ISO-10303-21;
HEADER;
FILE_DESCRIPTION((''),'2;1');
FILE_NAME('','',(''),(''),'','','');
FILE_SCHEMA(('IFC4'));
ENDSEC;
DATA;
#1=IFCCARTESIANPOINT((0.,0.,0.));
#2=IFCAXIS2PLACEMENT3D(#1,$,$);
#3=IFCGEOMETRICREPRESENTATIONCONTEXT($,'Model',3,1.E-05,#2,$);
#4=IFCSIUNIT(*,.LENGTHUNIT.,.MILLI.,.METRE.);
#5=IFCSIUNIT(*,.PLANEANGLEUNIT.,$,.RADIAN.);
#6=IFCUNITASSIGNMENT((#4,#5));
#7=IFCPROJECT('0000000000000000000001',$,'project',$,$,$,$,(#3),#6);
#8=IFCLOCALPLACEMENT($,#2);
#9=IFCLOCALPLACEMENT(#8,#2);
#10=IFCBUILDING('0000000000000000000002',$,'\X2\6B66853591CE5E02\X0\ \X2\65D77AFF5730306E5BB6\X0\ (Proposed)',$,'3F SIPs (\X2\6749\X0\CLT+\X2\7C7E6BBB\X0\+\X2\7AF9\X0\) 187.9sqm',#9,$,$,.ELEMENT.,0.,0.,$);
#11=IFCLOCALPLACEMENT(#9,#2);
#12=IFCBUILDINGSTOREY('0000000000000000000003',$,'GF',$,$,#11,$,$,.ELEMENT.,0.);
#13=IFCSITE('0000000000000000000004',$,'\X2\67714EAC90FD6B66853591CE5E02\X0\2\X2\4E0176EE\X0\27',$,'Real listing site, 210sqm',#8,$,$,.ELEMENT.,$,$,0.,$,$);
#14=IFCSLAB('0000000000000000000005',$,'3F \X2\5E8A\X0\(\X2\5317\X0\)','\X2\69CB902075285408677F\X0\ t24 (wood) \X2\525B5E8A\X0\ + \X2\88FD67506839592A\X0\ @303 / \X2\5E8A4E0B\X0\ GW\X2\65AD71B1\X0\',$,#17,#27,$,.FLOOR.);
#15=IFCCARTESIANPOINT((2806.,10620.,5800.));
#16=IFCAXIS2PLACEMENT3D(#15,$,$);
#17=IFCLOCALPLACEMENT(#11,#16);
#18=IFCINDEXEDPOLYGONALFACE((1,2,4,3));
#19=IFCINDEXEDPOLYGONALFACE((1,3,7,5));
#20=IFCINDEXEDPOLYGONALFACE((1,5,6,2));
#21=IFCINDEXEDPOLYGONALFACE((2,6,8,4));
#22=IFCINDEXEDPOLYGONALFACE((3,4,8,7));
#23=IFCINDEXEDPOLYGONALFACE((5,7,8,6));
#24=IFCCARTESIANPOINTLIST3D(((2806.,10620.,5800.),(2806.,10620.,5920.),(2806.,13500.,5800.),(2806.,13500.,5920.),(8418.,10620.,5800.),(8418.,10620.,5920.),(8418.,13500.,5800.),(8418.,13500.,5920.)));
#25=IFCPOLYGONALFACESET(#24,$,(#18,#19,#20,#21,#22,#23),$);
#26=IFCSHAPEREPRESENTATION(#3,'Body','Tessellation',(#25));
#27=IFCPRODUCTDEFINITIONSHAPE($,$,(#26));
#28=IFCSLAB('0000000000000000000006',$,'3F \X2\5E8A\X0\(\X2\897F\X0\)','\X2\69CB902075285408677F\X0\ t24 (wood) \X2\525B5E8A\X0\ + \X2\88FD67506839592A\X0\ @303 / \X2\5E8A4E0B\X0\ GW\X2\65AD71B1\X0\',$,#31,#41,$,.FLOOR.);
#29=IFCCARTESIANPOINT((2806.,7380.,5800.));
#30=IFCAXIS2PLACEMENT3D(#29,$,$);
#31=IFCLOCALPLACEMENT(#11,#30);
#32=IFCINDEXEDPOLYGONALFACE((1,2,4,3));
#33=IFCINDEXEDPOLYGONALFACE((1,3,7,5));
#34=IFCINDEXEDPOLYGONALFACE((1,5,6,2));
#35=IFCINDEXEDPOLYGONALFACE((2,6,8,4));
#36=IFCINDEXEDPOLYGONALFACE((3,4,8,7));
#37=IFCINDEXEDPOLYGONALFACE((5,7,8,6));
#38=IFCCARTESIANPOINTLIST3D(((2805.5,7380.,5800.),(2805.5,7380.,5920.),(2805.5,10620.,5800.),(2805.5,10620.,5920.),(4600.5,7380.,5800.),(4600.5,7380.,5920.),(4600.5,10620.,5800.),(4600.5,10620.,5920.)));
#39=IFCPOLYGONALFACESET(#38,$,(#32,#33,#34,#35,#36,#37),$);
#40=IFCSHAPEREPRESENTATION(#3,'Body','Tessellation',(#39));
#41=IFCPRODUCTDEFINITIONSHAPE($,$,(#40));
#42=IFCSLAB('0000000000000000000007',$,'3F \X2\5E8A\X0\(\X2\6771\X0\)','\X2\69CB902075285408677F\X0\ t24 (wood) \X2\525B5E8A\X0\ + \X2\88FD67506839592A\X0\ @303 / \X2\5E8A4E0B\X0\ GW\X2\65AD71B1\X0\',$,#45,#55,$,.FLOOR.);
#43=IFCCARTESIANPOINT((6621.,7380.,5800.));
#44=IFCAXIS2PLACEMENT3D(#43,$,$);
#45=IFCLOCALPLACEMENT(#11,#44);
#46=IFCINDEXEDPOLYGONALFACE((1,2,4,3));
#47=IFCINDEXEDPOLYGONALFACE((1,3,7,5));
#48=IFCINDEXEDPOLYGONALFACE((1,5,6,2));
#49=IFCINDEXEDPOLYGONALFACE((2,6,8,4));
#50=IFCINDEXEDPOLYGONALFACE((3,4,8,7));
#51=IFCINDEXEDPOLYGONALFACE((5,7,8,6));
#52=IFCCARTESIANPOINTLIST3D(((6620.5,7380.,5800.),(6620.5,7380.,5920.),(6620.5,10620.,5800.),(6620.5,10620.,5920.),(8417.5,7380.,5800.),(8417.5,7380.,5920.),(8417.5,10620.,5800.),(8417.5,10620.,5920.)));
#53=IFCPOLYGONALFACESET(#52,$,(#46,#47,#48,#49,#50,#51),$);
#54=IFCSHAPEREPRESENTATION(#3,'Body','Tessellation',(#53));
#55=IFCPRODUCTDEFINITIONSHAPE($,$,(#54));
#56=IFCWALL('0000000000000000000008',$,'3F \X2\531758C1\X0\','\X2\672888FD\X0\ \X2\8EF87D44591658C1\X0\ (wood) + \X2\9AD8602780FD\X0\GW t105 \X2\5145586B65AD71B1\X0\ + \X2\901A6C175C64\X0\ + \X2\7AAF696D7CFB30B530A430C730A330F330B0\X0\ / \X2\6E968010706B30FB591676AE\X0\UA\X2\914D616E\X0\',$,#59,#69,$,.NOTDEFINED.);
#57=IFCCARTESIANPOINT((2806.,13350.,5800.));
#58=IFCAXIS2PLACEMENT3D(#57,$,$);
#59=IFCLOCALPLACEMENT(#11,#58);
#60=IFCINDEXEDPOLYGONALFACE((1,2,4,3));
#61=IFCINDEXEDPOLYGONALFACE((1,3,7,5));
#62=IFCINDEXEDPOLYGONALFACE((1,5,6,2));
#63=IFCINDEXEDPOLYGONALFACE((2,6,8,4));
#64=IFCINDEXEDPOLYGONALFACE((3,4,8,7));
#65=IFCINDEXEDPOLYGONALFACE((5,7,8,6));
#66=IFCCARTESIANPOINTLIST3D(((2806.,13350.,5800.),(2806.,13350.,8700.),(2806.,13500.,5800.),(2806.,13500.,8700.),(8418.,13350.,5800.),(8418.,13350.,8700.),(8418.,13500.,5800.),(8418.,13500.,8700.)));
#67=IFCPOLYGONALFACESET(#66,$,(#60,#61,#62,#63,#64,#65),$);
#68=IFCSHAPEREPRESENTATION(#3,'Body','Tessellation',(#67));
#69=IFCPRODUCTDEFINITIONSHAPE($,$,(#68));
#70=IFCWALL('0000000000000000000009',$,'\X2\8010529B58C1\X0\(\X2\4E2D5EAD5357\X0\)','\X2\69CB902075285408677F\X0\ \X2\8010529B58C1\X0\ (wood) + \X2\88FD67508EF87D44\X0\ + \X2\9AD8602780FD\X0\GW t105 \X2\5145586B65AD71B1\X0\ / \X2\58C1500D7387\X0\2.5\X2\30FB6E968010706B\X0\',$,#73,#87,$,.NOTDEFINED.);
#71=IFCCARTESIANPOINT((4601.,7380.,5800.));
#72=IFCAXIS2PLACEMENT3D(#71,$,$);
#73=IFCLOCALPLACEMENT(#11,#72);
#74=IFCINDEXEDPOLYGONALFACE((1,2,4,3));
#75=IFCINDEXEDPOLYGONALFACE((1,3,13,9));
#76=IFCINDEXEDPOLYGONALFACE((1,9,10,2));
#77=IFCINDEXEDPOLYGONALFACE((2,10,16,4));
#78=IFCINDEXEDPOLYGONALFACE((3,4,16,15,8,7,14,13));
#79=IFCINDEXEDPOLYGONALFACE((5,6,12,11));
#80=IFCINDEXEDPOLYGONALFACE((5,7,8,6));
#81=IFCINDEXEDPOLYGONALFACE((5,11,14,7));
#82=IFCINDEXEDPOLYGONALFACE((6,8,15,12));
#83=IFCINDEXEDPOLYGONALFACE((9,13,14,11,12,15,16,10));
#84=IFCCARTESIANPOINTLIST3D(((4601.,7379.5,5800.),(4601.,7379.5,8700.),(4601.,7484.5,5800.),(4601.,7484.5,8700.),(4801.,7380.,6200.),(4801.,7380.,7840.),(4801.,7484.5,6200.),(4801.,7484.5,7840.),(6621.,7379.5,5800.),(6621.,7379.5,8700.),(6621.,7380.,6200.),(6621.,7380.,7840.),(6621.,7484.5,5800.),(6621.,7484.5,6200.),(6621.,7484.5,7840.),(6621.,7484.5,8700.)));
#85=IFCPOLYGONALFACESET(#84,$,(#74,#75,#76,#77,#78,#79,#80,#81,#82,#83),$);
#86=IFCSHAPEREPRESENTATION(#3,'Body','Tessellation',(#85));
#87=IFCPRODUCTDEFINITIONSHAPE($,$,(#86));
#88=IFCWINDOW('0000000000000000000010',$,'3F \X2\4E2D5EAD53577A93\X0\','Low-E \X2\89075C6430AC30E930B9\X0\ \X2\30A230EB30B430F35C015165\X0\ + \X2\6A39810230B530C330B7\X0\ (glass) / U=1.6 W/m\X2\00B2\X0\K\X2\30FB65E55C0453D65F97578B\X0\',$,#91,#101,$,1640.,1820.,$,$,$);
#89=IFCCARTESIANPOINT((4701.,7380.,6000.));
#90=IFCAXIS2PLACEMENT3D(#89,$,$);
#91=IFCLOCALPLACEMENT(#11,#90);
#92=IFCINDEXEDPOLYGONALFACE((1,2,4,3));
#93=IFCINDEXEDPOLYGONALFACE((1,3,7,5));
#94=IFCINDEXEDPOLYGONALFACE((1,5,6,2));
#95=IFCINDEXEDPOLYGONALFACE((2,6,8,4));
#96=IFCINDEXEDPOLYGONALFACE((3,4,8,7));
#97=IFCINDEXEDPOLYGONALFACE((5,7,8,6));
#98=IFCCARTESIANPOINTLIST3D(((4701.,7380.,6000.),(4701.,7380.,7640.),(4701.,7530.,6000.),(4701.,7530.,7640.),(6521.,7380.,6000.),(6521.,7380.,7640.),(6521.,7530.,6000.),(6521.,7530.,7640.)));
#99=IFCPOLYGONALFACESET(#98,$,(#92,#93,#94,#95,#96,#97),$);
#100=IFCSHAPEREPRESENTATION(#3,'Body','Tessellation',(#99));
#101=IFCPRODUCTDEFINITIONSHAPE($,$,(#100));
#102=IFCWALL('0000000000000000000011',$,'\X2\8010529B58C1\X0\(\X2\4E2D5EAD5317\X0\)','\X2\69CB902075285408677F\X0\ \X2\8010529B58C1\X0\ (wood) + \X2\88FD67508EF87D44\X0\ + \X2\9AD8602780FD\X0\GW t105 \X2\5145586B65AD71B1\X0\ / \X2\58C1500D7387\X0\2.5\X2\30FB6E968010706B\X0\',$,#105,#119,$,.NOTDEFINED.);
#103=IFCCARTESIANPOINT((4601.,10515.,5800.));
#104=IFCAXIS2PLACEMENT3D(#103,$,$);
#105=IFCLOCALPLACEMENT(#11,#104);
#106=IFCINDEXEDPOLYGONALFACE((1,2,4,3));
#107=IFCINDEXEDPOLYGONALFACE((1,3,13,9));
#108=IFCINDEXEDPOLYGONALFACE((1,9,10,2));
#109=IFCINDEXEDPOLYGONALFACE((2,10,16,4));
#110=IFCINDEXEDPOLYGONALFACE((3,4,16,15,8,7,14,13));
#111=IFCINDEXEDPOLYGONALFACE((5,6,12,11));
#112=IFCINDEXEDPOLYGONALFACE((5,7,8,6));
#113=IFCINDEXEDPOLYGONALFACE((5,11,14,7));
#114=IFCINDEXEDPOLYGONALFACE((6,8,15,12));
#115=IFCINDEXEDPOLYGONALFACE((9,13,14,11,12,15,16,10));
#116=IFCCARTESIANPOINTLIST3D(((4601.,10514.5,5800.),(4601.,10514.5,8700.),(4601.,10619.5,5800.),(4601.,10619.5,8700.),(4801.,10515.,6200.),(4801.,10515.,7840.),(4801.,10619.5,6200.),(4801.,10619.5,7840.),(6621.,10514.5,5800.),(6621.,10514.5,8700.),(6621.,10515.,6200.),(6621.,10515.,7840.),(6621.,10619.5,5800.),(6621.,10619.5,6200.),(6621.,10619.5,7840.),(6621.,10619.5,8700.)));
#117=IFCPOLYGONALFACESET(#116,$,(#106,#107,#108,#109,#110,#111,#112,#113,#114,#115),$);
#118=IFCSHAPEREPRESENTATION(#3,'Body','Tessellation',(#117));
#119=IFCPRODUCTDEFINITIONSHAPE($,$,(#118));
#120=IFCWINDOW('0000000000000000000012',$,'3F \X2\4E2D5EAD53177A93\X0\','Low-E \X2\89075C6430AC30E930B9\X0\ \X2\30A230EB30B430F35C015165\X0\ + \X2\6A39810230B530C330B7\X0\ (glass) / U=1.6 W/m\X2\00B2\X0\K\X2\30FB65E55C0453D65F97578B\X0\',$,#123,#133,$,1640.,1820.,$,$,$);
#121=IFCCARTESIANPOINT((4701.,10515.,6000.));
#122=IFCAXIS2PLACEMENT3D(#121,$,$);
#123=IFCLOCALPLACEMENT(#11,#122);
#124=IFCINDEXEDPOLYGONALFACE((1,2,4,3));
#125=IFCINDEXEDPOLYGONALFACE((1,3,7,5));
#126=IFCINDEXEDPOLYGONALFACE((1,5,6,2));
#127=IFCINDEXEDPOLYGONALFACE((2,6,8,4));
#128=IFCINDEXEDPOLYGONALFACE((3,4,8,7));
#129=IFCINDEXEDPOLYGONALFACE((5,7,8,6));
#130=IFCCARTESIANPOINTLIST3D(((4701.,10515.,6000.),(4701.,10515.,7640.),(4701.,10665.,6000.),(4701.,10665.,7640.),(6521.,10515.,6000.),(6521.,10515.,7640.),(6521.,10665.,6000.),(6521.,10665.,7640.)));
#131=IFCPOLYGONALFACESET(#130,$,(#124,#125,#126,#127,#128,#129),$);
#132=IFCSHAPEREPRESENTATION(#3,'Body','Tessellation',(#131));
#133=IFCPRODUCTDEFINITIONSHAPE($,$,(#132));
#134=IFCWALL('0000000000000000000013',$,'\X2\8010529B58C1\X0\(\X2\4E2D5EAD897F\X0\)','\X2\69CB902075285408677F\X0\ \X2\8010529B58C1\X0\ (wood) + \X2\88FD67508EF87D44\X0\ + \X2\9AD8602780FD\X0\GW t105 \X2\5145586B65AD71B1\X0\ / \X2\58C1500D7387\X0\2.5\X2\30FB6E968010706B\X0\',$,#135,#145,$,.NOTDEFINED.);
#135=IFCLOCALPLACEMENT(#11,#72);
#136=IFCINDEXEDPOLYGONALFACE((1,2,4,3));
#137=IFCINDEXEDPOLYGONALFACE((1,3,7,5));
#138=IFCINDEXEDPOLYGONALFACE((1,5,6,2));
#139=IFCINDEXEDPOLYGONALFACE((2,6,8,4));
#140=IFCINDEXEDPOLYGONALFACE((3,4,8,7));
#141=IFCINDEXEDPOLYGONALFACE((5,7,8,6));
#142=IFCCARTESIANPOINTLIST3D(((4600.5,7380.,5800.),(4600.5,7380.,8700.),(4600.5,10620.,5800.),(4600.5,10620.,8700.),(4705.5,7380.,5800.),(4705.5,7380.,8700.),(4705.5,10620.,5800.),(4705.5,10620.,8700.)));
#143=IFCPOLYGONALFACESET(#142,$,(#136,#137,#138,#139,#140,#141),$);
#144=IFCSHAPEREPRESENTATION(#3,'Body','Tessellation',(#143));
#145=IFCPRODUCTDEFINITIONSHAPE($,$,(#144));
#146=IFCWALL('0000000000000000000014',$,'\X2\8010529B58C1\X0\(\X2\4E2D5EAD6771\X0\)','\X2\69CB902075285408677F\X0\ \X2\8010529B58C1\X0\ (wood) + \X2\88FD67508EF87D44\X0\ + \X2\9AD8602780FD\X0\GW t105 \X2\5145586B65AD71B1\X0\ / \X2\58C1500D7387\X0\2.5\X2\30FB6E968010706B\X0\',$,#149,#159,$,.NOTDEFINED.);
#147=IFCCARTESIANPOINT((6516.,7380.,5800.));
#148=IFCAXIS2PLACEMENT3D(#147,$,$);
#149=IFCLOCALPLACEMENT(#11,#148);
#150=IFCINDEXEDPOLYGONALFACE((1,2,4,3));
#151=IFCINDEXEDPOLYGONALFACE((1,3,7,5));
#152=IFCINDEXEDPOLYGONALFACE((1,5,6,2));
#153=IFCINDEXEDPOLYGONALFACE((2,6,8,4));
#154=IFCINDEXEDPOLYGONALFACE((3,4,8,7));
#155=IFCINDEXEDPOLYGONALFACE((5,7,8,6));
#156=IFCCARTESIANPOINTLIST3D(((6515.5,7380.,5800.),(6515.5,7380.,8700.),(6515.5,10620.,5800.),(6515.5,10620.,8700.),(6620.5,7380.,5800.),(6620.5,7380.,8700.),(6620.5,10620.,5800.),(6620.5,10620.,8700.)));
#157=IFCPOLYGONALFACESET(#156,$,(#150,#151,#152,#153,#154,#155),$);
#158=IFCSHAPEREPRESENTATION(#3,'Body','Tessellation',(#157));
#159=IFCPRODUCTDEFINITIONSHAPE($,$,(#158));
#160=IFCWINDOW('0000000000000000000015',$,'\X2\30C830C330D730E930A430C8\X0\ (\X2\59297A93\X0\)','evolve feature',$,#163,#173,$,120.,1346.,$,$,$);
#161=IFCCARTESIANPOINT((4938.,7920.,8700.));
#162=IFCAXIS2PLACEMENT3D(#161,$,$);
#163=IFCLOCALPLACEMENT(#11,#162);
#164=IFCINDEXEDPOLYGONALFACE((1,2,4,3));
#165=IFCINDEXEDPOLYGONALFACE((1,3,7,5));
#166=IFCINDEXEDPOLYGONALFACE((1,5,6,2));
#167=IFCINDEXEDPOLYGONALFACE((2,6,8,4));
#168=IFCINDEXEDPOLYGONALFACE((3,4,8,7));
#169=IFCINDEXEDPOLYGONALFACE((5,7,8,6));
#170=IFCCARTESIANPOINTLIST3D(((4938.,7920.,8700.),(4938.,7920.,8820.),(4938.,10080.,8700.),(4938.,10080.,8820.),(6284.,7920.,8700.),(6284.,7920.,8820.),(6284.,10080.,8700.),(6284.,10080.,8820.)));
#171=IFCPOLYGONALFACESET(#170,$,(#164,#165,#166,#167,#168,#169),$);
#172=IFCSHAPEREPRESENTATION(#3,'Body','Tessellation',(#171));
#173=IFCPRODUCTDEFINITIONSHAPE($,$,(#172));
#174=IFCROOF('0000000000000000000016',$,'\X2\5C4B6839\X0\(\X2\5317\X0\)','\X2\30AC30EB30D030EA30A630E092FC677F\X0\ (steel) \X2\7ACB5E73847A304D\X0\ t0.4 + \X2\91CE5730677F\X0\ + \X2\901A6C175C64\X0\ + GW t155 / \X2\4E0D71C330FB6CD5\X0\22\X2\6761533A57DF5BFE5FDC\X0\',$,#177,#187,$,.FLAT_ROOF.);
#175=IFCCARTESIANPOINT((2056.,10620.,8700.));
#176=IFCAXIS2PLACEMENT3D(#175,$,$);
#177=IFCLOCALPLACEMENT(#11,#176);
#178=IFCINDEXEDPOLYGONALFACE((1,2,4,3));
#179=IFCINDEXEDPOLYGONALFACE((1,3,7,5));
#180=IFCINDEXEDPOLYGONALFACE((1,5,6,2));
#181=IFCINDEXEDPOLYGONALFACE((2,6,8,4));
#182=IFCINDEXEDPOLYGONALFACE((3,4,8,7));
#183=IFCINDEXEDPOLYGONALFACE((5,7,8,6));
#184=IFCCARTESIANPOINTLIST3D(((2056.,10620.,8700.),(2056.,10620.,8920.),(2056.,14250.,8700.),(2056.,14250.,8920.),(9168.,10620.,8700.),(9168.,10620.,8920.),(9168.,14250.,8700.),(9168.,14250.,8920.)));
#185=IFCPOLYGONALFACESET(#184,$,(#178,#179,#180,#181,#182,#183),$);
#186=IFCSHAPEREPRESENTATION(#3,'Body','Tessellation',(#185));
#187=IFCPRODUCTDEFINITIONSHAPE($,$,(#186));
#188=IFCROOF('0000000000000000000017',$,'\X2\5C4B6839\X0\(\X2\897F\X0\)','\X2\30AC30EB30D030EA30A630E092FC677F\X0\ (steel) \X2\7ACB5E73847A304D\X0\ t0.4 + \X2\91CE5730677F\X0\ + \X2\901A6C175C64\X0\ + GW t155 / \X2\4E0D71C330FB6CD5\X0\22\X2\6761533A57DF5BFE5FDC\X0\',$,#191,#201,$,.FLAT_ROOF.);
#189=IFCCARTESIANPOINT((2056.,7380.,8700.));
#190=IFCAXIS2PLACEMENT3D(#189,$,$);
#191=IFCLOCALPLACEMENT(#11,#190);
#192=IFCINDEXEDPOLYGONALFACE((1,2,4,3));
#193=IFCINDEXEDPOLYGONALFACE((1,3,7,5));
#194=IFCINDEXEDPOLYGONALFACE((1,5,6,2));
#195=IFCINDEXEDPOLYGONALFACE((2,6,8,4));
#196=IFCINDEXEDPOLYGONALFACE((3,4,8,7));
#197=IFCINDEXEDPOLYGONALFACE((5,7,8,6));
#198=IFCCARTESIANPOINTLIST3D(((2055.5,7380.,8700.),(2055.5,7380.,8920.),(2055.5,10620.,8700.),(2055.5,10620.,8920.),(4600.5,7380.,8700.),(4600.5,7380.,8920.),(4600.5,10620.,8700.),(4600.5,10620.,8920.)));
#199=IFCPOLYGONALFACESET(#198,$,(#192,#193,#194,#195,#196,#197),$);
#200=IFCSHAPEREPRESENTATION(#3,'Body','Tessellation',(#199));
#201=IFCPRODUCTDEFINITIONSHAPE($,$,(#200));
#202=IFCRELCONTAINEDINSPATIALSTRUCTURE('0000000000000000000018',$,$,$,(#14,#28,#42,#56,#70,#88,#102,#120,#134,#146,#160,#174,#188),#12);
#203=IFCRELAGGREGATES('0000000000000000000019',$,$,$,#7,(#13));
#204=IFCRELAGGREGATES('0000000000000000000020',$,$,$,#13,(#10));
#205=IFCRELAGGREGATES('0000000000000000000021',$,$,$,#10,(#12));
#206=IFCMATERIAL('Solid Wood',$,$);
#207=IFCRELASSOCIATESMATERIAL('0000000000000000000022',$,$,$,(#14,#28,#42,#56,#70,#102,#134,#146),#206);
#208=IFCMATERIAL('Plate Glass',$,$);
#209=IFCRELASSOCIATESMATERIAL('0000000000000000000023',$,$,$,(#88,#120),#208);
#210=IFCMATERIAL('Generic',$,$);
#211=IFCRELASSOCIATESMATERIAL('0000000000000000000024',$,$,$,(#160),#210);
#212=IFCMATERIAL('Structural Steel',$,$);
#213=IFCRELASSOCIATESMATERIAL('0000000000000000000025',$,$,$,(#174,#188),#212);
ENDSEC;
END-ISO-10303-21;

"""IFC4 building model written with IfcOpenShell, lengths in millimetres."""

from ifc_helpers import new_model, si_unit, frame, frame_2d, origin, place, context, project, spatial, rectangle, extrude, material, element, fill, save


model = new_model("IFC4")

# Units and contexts
model_context = context("Model", 3, precision=1e-05, world=origin())
ifc_project = project(units=[si_unit("LENGTHUNIT", "METRE", prefix="MILLI"), si_unit("PLANEANGLEUNIT", "RADIAN")], contexts=[model_context])

# Site, building, storey
site_placement = place(None, origin())
site = spatial("IfcSite", under=ifc_project, at=site_placement, Name="東京都武蔵野市2丁目27", ObjectType="Real listing site, 210sqm", CompositionType="ELEMENT", RefElevation=0.0)
building_placement = place(site_placement, origin())
building = spatial("IfcBuilding", under=site, at=building_placement, Name="武蔵野市 旗竿地の家 (Proposed)", ObjectType="3F SIPs (杉CLT+籾殻+竹) 187.9sqm", CompositionType="ELEMENT", ElevationOfRefHeight=0.0, ElevationOfTerrain=0.0)
storey_placement = place(building_placement, origin())
storey = spatial("IfcBuildingStorey", under=building, at=storey_placement, Name="GF", CompositionType="ELEMENT", Elevation=0.0)

# Slabs
ifc_material_1 = material(Name="Solid Wood")
slab_1_placement = place(storey_placement, frame((2806.0, 10620.0, 5800.0)))
element("IfcSlab", 1, at=slab_1_placement, inside=storey, material=ifc_material_1, Name="3F 床(北)", Description="構造用合板 t24 (wood) 剛床 + 製材根太 @303 / 床下 GW断熱", PredefinedType="FLOOR", context=model_context, shape_type="SweptSolid", body=[
    extrude(rectangle(XDim=5612.0, YDim=2880.0, at=frame_2d((2806.0, 1440.0))), frame((2806.0, 10620.0, 5800.0)), (0.0, 0.0, 1.0), 120.0),
])
slab_2_placement = place(storey_placement, frame((2806.0, 7380.0, 5800.0)))
element("IfcSlab", 2, at=slab_2_placement, inside=storey, material=ifc_material_1, Name="3F 床(西)", Description="構造用合板 t24 (wood) 剛床 + 製材根太 @303 / 床下 GW断熱", PredefinedType="FLOOR", context=model_context, shape_type="SweptSolid", body=[
    extrude(rectangle(XDim=1795.0, YDim=3240.0, at=frame_2d((897.0, 1620.0))), frame((2806.0, 7380.0, 5800.0)), (0.0, 0.0, 1.0), 120.0),
])
slab_3_placement = place(storey_placement, frame((6621.0, 7380.0, 5800.0)))
element("IfcSlab", 3, at=slab_3_placement, inside=storey, material=ifc_material_1, Name="3F 床(東)", Description="構造用合板 t24 (wood) 剛床 + 製材根太 @303 / 床下 GW断熱", PredefinedType="FLOOR", context=model_context, shape_type="SweptSolid", body=[
    extrude(rectangle(XDim=1797.0, YDim=3240.0, at=frame_2d((898.0, 1620.0))), frame((6621.0, 7380.0, 5800.0)), (0.0, 0.0, 1.0), 120.0),
])

# Wall
wall_1_placement = place(storey_placement, frame((2806.0, 13350.0, 5800.0)))
element("IfcWall", 4, at=wall_1_placement, inside=storey, material=ifc_material_1, Name="3F 北壁", Description="木製 軸組外壁 (wood) + 高性能GW t105 充填断熱 + 通気層 + 窯業系サイディング / 準耐火・外皮UA配慮", PredefinedType="NOTDEFINED", context=model_context, shape_type="SweptSolid", body=[
    extrude(rectangle(XDim=5612.0, YDim=150.0, at=frame_2d((2806.0, 75.0))), frame((2806.0, 13350.0, 5800.0)), (0.0, 0.0, 1.0), 2900.0),
])

# Walls, openings, windows
wall_2_placement = place(storey_placement, frame((4601.0, 7380.0, 5800.0)))
wall_2 = element("IfcWall", 5, at=wall_2_placement, inside=storey, material=ifc_material_1, Name="耐力壁(中庭南)", Description="構造用合板 耐力壁 (wood) + 製材軸組 + 高性能GW t105 充填断熱 / 壁倍率2.5・準耐火", PredefinedType="NOTDEFINED", context=model_context, shape_type="SweptSolid", body=[
    extrude(rectangle(XDim=2020.0, YDim=105.0, at=frame_2d((1010.0, 52.0))), frame((4601.0, 7380.0, 5800.0)), (0.0, 0.0, 1.0), 2900.0),
])
opening_1_placement = place(storey_placement, frame((4701.0, 7380.0, 6000.0)))
opening_1 = element("IfcOpeningElement", 6, at=opening_1_placement, cuts=wall_2, PredefinedType="NOTDEFINED", context=model_context, shape_type="SweptSolid", body=[
    extrude(rectangle(XDim=1820.0, YDim=150.0, at=frame_2d((910.0, 75.0))), frame((4701.0, 7380.0, 6000.0)), (0.0, 0.0, 1.0), 1640.0),
])
ifc_material_2 = material(Name="Plate Glass")
window_1_placement = place(storey_placement, frame((4701.0, 7380.0, 6000.0)))
window_1 = element("IfcWindow", 7, at=window_1_placement, inside=storey, material=ifc_material_2, Name="3F 中庭南窓", Description="Low-E 複層ガラス アルゴン封入 + 樹脂サッシ (glass) / U=1.6 W/m²K・日射取得型", OverallHeight=1640.0, OverallWidth=1820.0, context=model_context, shape_type="SweptSolid", body=[
    extrude(rectangle(XDim=1820.0, YDim=150.0, at=frame_2d((910.0, 75.0))), frame((4701.0, 7380.0, 6000.0)), (0.0, 0.0, 1.0), 1640.0),
])
fill(opening_1, window_1)
wall_3_placement = place(storey_placement, frame((4601.0, 10515.0, 5800.0)))
wall_3 = element("IfcWall", 8, at=wall_3_placement, inside=storey, material=ifc_material_1, Name="耐力壁(中庭北)", Description="構造用合板 耐力壁 (wood) + 製材軸組 + 高性能GW t105 充填断熱 / 壁倍率2.5・準耐火", PredefinedType="NOTDEFINED", context=model_context, shape_type="SweptSolid", body=[
    extrude(rectangle(XDim=2020.0, YDim=105.0, at=frame_2d((1010.0, 52.0))), frame((4601.0, 10515.0, 5800.0)), (0.0, 0.0, 1.0), 2900.0),
])
opening_2_placement = place(storey_placement, frame((4701.0, 10515.0, 6000.0)))
opening_2 = element("IfcOpeningElement", 9, at=opening_2_placement, cuts=wall_3, PredefinedType="NOTDEFINED", context=model_context, shape_type="SweptSolid", body=[
    extrude(rectangle(XDim=1820.0, YDim=150.0, at=frame_2d((910.0, 75.0))), frame((4701.0, 10515.0, 6000.0)), (0.0, 0.0, 1.0), 1640.0),
])
window_2_placement = place(storey_placement, frame((4701.0, 10515.0, 6000.0)))
window_2 = element("IfcWindow", 10, at=window_2_placement, inside=storey, material=ifc_material_2, Name="3F 中庭北窓", Description="Low-E 複層ガラス アルゴン封入 + 樹脂サッシ (glass) / U=1.6 W/m²K・日射取得型", OverallHeight=1640.0, OverallWidth=1820.0, context=model_context, shape_type="SweptSolid", body=[
    extrude(rectangle(XDim=1820.0, YDim=150.0, at=frame_2d((910.0, 75.0))), frame((4701.0, 10515.0, 6000.0)), (0.0, 0.0, 1.0), 1640.0),
])
fill(opening_2, window_2)

# Walls
wall_4_placement = place(storey_placement, frame((4601.0, 7380.0, 5800.0)))
element("IfcWall", 11, at=wall_4_placement, inside=storey, material=ifc_material_1, Name="耐力壁(中庭西)", Description="構造用合板 耐力壁 (wood) + 製材軸組 + 高性能GW t105 充填断熱 / 壁倍率2.5・準耐火", PredefinedType="NOTDEFINED", context=model_context, shape_type="SweptSolid", body=[
    extrude(rectangle(XDim=105.0, YDim=3240.0, at=frame_2d((52.0, 1620.0))), frame((4601.0, 7380.0, 5800.0)), (0.0, 0.0, 1.0), 2900.0),
])
wall_5_placement = place(storey_placement, frame((6516.0, 7380.0, 5800.0)))
element("IfcWall", 12, at=wall_5_placement, inside=storey, material=ifc_material_1, Name="耐力壁(中庭東)", Description="構造用合板 耐力壁 (wood) + 製材軸組 + 高性能GW t105 充填断熱 / 壁倍率2.5・準耐火", PredefinedType="NOTDEFINED", context=model_context, shape_type="SweptSolid", body=[
    extrude(rectangle(XDim=105.0, YDim=3240.0, at=frame_2d((52.0, 1620.0))), frame((6516.0, 7380.0, 5800.0)), (0.0, 0.0, 1.0), 2900.0),
])

# Window
ifc_material_3 = material(Name="Generic")
window_3_placement = place(storey_placement, frame((4938.0, 7920.0, 8700.0)))
element("IfcWindow", 13, at=window_3_placement, inside=storey, material=ifc_material_3, Name="トップライト (天窓)", Description="evolve feature", OverallHeight=120.0, OverallWidth=1346.0, context=model_context, shape_type="SweptSolid", body=[
    extrude(rectangle(XDim=1346.0, YDim=2160.0, at=frame_2d((673.0, 1080.0))), frame((4938.0, 7920.0, 8700.0)), (0.0, 0.0, 1.0), 120.0),
])

# Roofs
ifc_material_4 = material(Name="Structural Steel")
for number, where, name in (
    (14, (2056.0, 10620.0, 8700.0), "屋根(北)"),
):
    element("IfcRoof", number, at=place(storey_placement, frame(where)), inside=storey, material=ifc_material_4, Name=name, Description="ガルバリウム鋼板 (steel) 立平葺き t0.4 + 野地板 + 通気層 + GW t155 / 不燃・法22条区域対応", PredefinedType="FLAT_ROOF", context=model_context, shape_type="SweptSolid", body=[
        extrude(rectangle(XDim=7112.0, YDim=3630.0, at=frame_2d((3556.0, 1815.0))), frame((2056.0, 10620.0, 8700.0)), (0.0, 0.0, 1.0), 220.0),
    ])
roof_1_placement = place(storey_placement, frame((2056.0, 7380.0, 8700.0)))
element("IfcRoof", 15, at=roof_1_placement, inside=storey, material=ifc_material_4, Name="屋根(西)", Description="ガルバリウム鋼板 (steel) 立平葺き t0.4 + 野地板 + 通気層 + GW t155 / 不燃・法22条区域対応", PredefinedType="FLAT_ROOF", context=model_context, shape_type="SweptSolid", body=[
    extrude(rectangle(XDim=2545.0, YDim=3240.0, at=frame_2d((1272.0, 1620.0))), frame((2056.0, 7380.0, 8700.0)), (0.0, 0.0, 1.0), 220.0),
])

save(model, "model.ifc")
